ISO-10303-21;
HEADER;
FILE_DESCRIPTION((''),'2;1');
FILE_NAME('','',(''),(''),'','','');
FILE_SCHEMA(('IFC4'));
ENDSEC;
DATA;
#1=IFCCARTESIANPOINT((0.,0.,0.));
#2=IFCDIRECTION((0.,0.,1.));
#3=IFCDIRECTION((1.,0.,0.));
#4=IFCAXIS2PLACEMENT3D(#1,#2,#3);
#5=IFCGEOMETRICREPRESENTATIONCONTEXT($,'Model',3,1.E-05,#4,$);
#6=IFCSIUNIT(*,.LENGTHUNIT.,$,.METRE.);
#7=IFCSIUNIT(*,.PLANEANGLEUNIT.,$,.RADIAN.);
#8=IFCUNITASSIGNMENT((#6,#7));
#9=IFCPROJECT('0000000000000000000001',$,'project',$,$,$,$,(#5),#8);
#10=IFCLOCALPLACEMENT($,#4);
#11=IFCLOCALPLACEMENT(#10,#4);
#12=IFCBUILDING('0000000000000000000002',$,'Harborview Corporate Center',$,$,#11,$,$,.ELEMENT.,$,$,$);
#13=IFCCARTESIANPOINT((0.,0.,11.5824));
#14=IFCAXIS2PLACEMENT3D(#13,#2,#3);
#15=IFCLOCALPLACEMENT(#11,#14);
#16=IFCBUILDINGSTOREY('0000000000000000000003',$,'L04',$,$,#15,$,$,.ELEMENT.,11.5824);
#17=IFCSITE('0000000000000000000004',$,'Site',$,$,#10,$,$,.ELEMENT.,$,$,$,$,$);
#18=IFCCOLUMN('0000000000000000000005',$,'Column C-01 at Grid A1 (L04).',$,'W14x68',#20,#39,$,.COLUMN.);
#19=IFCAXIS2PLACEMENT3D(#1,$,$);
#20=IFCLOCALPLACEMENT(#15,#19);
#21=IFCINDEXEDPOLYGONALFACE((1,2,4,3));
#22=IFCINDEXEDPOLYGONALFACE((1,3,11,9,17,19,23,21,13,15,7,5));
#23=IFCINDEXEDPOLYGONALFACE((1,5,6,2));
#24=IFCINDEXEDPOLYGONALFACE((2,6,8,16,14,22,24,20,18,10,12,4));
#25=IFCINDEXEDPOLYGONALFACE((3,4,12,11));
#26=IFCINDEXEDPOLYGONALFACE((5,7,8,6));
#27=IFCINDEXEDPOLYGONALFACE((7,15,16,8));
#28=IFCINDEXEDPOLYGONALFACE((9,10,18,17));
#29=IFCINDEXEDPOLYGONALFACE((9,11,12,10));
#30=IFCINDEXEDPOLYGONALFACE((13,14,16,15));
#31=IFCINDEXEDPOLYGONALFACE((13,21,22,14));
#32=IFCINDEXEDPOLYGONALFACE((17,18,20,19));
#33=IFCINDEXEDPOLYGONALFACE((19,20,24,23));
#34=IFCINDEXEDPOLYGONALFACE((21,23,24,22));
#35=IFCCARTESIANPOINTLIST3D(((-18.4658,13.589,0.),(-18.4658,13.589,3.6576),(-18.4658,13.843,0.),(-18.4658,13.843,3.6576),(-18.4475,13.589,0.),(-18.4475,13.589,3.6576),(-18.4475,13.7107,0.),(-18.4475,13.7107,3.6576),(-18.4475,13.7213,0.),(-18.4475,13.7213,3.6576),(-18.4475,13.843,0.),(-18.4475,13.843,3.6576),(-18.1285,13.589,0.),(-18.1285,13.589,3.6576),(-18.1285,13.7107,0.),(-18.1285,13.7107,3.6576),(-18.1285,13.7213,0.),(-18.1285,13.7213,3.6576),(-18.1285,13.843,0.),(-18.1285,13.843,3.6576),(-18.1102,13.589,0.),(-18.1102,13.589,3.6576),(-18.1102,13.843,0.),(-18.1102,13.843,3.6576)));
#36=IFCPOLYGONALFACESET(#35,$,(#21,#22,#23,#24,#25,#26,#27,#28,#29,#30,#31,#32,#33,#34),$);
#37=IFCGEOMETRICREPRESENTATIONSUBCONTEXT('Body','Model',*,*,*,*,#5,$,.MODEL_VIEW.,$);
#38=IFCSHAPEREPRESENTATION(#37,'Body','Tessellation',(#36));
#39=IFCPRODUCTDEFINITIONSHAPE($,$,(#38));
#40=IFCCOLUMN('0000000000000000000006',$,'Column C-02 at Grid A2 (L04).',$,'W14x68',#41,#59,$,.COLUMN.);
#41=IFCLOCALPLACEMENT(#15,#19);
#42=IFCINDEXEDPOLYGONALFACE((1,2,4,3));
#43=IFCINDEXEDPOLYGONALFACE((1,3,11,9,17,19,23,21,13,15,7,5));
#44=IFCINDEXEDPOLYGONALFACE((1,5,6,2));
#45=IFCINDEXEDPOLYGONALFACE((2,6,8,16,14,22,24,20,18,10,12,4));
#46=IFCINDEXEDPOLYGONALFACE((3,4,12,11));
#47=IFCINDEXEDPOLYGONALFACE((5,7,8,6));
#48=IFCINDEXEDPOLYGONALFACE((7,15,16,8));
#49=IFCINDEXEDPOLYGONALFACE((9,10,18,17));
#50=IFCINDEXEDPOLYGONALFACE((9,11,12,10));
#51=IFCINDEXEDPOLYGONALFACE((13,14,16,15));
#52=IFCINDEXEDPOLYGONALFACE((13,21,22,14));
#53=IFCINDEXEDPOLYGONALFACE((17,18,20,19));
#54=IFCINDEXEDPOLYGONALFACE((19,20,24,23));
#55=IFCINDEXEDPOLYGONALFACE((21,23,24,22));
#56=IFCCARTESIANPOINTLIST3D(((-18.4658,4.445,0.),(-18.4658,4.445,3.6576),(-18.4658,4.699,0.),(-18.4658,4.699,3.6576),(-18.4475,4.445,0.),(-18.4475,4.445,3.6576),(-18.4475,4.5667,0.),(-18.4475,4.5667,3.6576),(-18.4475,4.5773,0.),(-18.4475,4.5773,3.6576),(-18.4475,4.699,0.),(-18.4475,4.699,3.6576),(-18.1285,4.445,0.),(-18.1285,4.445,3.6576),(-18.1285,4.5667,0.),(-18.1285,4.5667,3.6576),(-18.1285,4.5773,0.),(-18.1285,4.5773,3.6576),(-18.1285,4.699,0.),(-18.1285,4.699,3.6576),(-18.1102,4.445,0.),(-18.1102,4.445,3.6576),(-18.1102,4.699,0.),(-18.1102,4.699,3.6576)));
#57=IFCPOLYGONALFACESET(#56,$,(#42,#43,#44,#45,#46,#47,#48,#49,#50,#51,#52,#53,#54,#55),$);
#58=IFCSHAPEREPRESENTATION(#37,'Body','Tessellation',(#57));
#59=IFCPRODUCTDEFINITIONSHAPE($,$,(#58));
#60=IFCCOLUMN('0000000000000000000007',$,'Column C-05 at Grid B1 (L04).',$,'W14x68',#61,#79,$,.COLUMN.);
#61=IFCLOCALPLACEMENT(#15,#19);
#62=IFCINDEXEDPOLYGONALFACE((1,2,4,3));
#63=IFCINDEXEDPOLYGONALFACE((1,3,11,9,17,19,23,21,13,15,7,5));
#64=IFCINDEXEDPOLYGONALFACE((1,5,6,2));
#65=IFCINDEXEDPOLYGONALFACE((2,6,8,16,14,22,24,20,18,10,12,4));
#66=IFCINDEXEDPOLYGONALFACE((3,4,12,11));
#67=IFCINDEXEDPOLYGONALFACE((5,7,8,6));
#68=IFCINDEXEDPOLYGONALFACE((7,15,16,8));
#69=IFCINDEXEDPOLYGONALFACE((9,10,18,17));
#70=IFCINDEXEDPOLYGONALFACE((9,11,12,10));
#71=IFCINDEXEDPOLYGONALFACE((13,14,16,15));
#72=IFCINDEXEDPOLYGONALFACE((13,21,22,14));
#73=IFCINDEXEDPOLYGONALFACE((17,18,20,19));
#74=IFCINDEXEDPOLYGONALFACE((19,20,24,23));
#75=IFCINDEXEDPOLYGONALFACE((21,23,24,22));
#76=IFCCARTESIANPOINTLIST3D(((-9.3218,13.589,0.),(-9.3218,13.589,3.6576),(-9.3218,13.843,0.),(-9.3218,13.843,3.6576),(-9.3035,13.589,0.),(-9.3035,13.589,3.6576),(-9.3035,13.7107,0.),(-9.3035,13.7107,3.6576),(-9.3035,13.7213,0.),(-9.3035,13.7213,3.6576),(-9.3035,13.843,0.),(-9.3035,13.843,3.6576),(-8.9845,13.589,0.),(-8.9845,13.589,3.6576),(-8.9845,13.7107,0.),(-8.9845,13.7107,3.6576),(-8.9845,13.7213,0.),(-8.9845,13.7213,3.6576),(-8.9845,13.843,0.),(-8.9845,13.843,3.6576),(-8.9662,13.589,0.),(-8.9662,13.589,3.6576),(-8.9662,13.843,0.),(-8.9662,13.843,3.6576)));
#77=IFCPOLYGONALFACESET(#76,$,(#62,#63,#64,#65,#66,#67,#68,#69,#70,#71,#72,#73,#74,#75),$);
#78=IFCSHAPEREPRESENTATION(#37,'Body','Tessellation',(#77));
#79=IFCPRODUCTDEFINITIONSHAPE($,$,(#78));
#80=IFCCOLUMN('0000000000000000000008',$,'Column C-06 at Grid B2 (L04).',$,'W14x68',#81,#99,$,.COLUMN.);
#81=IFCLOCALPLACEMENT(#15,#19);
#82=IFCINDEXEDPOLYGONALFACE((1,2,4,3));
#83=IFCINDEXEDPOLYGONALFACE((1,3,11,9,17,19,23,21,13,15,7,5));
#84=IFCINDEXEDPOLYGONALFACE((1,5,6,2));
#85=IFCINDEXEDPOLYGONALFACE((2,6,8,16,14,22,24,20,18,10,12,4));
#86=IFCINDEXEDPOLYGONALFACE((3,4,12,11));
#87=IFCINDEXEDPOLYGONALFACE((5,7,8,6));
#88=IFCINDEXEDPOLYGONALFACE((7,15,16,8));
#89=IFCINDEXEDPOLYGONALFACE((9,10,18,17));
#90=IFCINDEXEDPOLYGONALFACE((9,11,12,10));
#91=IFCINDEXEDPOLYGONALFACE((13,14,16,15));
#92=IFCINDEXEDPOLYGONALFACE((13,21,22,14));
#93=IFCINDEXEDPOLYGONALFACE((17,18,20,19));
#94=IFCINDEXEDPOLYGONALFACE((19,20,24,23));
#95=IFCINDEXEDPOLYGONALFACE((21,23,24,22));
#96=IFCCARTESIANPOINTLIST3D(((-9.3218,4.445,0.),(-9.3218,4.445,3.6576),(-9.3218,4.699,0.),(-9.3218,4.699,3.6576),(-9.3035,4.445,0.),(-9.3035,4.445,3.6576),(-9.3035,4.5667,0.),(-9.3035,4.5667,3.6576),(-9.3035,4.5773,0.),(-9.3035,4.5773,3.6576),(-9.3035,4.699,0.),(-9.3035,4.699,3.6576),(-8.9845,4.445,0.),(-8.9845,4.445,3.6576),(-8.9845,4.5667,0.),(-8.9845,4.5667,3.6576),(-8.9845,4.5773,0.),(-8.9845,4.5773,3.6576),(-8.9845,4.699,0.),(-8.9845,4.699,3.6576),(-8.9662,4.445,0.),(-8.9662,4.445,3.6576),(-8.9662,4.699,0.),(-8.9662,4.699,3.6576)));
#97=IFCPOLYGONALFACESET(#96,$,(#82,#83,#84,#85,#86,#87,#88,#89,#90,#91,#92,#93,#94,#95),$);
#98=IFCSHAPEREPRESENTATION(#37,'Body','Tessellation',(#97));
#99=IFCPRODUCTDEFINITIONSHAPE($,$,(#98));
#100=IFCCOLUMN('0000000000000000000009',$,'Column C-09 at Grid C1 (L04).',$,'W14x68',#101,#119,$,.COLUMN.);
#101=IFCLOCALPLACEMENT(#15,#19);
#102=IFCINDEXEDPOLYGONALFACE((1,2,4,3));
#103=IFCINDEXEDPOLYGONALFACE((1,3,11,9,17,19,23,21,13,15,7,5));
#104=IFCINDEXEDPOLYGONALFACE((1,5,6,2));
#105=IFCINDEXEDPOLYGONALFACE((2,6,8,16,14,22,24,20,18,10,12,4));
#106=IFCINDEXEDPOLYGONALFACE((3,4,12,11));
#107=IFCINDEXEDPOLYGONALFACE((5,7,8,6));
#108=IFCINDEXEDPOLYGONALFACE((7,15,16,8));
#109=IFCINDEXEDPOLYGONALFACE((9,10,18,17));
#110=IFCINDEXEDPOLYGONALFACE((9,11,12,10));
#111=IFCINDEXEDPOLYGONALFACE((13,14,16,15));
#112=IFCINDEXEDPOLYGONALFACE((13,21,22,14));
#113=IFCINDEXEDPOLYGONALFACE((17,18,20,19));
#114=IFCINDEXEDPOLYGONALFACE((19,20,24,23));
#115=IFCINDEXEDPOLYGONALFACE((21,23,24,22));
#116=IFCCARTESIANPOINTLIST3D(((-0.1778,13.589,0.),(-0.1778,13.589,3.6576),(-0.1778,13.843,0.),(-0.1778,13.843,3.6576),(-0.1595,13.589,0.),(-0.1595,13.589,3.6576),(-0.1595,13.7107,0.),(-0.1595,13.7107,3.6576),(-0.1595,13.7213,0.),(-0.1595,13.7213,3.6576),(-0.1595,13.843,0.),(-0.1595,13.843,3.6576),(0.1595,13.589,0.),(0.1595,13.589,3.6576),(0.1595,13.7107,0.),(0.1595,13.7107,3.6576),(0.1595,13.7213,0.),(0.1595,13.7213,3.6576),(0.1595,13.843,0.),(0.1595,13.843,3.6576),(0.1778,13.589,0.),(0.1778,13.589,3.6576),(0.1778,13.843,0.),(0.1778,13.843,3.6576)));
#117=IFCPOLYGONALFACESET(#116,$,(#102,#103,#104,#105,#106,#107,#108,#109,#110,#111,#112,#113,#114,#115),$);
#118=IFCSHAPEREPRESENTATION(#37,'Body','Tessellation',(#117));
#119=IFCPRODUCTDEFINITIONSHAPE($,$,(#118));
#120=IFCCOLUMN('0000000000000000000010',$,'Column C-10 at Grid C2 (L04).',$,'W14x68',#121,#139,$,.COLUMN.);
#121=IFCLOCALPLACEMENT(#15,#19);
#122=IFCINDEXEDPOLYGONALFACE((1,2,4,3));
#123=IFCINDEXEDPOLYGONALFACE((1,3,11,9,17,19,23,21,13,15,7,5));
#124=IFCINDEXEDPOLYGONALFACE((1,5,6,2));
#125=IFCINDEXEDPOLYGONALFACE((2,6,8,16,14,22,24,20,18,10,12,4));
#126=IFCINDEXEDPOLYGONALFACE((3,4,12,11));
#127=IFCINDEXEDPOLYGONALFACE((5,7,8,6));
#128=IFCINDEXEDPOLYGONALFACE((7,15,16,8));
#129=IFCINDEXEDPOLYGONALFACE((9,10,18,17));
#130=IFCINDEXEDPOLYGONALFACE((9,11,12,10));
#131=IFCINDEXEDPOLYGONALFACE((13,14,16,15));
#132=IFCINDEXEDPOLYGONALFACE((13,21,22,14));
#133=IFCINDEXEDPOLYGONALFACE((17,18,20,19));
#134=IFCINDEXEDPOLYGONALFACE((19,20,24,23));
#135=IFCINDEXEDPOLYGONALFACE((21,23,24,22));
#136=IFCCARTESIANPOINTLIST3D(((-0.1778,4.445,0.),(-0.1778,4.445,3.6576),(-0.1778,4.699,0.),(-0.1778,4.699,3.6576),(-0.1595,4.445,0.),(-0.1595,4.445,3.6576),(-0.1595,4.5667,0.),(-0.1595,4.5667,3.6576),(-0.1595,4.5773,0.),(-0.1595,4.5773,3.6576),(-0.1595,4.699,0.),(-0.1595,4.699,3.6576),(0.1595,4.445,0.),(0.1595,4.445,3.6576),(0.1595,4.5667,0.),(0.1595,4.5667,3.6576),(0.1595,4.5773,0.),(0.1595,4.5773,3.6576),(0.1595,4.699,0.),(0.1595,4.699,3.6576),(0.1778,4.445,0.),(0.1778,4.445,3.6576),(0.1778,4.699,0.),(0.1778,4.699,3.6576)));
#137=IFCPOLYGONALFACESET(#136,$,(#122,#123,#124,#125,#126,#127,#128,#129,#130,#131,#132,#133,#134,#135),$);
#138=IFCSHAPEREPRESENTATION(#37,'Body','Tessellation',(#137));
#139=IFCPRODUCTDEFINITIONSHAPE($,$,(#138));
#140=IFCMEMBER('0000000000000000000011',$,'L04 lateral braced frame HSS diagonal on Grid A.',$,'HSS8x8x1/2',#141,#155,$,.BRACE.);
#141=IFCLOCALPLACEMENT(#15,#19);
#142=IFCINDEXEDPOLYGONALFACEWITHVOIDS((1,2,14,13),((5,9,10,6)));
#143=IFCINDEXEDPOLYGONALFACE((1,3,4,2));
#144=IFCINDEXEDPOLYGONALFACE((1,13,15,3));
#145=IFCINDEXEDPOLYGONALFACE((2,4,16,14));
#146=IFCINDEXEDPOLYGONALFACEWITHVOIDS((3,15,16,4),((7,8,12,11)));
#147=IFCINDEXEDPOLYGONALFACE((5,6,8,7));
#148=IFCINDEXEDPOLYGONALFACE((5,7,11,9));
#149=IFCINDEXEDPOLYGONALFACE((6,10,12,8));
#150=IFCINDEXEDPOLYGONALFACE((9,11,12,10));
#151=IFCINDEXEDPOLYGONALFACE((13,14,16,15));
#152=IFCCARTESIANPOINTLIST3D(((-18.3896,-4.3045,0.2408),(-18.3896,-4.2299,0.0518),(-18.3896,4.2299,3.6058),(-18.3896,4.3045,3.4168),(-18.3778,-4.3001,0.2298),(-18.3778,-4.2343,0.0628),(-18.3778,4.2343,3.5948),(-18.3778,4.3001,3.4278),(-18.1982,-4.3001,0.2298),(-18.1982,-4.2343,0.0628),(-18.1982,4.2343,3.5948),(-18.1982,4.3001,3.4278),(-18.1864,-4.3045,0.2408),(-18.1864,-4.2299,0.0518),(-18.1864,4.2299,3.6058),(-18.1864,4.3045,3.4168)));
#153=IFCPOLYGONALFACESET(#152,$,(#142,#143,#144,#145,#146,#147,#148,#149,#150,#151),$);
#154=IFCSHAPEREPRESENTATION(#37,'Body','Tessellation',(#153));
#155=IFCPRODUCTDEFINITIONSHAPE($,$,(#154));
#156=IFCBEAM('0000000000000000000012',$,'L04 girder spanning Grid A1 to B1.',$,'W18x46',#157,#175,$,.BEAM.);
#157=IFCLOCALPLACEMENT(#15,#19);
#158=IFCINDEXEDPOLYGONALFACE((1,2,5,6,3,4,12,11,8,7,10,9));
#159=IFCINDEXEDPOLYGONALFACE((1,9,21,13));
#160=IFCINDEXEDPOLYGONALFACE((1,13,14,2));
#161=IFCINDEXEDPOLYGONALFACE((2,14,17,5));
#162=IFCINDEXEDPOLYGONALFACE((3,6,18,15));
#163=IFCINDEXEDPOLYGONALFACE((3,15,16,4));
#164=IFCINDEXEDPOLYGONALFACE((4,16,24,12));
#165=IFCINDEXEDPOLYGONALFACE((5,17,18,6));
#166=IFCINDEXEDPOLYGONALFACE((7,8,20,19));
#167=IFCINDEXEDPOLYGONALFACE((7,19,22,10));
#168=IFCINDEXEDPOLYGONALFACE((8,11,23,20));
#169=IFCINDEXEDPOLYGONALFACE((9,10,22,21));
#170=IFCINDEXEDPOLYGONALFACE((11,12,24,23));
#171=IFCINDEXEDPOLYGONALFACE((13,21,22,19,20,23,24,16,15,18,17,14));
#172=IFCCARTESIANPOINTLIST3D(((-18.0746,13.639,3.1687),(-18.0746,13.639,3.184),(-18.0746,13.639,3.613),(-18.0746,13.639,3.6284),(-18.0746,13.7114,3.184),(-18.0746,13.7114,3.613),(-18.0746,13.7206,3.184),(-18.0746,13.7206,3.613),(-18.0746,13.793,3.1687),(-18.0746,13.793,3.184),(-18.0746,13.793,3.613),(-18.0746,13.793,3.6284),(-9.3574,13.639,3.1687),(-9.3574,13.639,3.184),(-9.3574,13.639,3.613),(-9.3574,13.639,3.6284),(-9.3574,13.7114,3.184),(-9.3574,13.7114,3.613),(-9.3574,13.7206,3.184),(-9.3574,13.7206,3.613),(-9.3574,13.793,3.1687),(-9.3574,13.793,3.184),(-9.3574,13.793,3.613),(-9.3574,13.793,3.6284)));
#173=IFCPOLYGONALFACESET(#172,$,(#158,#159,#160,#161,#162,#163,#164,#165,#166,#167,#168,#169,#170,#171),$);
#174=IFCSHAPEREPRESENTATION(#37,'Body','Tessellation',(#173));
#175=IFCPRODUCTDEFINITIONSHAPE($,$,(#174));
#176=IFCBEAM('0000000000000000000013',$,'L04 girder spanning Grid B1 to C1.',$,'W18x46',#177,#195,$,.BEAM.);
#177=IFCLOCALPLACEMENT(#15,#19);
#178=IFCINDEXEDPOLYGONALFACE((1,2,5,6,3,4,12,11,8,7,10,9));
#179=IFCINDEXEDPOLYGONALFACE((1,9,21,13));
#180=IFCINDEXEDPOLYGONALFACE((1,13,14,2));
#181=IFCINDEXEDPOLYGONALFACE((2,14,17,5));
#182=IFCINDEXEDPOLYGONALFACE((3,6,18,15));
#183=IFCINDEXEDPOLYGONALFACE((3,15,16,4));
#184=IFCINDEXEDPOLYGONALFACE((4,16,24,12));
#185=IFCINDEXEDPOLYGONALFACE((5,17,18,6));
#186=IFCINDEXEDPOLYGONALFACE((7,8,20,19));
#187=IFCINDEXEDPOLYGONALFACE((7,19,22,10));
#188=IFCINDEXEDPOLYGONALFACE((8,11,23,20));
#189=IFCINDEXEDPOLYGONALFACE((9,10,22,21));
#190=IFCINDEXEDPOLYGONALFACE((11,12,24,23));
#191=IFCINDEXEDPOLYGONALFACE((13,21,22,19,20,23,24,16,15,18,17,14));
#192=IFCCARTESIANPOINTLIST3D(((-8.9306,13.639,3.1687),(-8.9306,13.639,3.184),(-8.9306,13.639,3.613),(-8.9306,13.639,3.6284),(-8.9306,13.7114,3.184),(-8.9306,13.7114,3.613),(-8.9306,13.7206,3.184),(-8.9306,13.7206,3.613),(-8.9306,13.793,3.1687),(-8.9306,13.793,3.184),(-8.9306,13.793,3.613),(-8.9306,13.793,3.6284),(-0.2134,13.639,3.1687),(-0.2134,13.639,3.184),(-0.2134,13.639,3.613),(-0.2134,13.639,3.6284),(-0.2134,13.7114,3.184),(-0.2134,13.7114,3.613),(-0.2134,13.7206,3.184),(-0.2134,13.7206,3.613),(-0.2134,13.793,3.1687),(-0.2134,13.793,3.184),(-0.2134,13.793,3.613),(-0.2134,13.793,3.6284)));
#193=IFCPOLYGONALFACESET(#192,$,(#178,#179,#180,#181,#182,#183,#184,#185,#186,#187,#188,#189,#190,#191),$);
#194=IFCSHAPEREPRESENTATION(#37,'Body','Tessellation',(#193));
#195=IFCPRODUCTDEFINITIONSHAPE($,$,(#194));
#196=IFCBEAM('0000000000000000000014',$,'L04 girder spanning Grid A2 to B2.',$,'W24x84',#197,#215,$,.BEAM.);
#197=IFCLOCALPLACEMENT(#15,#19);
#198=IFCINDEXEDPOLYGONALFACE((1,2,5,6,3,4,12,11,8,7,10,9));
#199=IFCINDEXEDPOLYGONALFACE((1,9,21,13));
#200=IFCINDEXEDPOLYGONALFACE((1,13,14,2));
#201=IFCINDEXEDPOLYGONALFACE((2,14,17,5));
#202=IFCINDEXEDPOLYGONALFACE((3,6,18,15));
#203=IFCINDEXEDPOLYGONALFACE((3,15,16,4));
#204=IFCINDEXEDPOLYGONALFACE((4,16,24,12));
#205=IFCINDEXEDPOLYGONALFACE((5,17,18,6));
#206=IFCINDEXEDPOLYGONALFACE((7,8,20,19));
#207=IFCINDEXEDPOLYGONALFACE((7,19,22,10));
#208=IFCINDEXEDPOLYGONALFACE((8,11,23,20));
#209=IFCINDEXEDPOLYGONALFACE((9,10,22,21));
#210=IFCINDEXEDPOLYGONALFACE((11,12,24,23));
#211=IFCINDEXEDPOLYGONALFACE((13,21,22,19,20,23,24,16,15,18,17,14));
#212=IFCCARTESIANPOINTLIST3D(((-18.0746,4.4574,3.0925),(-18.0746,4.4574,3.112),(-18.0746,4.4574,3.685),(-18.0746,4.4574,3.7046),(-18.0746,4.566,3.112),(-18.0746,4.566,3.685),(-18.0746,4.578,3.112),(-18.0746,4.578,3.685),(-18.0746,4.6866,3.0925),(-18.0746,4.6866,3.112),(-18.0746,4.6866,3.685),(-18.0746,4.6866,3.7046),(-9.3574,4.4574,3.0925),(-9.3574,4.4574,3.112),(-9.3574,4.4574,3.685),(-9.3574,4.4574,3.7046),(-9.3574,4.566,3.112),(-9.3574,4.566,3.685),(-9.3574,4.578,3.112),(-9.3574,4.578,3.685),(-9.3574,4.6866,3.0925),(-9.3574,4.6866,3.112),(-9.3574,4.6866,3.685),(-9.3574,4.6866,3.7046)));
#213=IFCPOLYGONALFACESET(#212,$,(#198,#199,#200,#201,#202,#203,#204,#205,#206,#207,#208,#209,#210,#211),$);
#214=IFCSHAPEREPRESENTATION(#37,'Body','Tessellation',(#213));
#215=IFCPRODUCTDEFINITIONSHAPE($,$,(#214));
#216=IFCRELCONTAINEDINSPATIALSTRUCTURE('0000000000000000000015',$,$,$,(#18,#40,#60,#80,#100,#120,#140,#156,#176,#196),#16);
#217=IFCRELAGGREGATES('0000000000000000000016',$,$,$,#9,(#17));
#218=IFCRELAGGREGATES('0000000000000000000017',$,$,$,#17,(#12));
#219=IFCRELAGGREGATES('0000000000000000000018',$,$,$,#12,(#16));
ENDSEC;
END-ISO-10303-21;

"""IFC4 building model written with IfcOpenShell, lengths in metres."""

from ifc_helpers import new_model, si_unit, frame, origin_with_axes, place, context, subcontext, project, spatial, hollow_rectangle, i_section, extrude, element, save


model = new_model("IFC4")

# Units and contexts
model_context = context("Model", 3, precision=1e-05, world=origin_with_axes())
body_context = subcontext(model_context, "Body", "Model", "MODEL_VIEW")
ifc_project = project(units=[si_unit("LENGTHUNIT", "METRE"), si_unit("PLANEANGLEUNIT", "RADIAN")], contexts=[model_context])

# Site, building, storey
site_placement = place(None, origin_with_axes())
site = spatial("IfcSite", under=ifc_project, at=site_placement, Name="Site", CompositionType="ELEMENT")
building_placement = place(site_placement, origin_with_axes())
building = spatial("IfcBuilding", under=site, at=building_placement, Name="Harborview Corporate Center", CompositionType="ELEMENT")
storey_placement = place(building_placement, frame((0.0, 0.0, 11.5824), z_axis=(0.0, 0.0, 1.0), x_axis=(1.0, 0.0, 0.0)))
storey = spatial("IfcBuildingStorey", under=building, at=storey_placement, Name="L04", CompositionType="ELEMENT", Elevation=11.5824)

# Columns
for number, where, z_axis, x_axis, name in (
    (1, (-18.288, 13.716, 0.0), (0.0, 0.0, 1.0), (0.0, 1.0, 0.0), "Column C-01 at Grid A1 (L04)."),
    (2, (-18.288, 4.572, 0.0), (0.0, 0.0, 1.0), (0.0, 1.0, 0.0), "Column C-02 at Grid A2 (L04)."),
    (3, (-9.144, 13.716, 0.0), (0.0, 0.0, 1.0), (0.0, 1.0, 0.0), "Column C-05 at Grid B1 (L04)."),
    (4, (-9.144, 4.572, 0.0), (0.0, 0.0, 1.0), (0.0, 1.0, 0.0), "Column C-06 at Grid B2 (L04)."),
    (5, (0.0, 13.716, 0.0), (0.0, 0.0, 1.0), (0.0, 1.0, 0.0), "Column C-09 at Grid C1 (L04)."),
    (6, (0.0, 4.572, 0.0), (0.0, 0.0, 1.0), (0.0, 1.0, 0.0), "Column C-10 at Grid C2 (L04)."),
):
    element("IfcColumn", number, at=place(storey_placement, frame(where, z_axis=z_axis, x_axis=x_axis)), inside=storey, Name=name, ObjectType="W14x68", PredefinedType="COLUMN", context=body_context, shape_type="SweptSolid", body=[
        extrude(i_section(OverallWidth=0.254, OverallDepth=0.3556, WebThickness=0.0105, FlangeThickness=0.0183), origin_with_axes(), (0.0, 0.0, 1.0), 3.6576),
    ])

# Member
member_placement = place(storey_placement, frame((-18.288, -4.2672, 0.1463), z_axis=(0.0, 0.930298, 0.366803), x_axis=(-1.0, 0.0, 0.0)))
element("IfcMember", 7, at=member_placement, inside=storey, Name="L04 lateral braced frame HSS diagonal on Grid A.", ObjectType="HSS8x8x1/2", PredefinedType="BRACE", context=body_context, shape_type="SweptSolid", body=[
    extrude(hollow_rectangle(XDim=0.2032, YDim=0.2032, WallThickness=0.0118), origin_with_axes(), (0.0, 0.0, 1.0), 9.1738),
])

# Beams
beam_1_placement = place(storey_placement, frame((-18.0746, 13.716, 3.3985), z_axis=(1.0, 0.0, 0.0), x_axis=(0.0, 1.0, 0.0)))
element("IfcBeam", 8, at=beam_1_placement, inside=storey, Name="L04 girder spanning Grid A1 to B1.", ObjectType="W18x46", PredefinedType="BEAM", context=body_context, shape_type="SweptSolid", body=[
    extrude(i_section(OverallWidth=0.1539, OverallDepth=0.4597, WebThickness=0.0091, FlangeThickness=0.0154), origin_with_axes(), (0.0, 0.0, 1.0), 8.7173),
])
beam_2_placement = place(storey_placement, frame((-8.9306, 13.716, 3.3985), z_axis=(1.0, 0.0, 0.0), x_axis=(0.0, 1.0, 0.0)))
element("IfcBeam", 9, at=beam_2_placement, inside=storey, Name="L04 girder spanning Grid B1 to C1.", ObjectType="W18x46", PredefinedType="BEAM", context=body_context, shape_type="SweptSolid", body=[
    extrude(i_section(OverallWidth=0.1539, OverallDepth=0.4597, WebThickness=0.0091, FlangeThickness=0.0154), origin_with_axes(), (0.0, 0.0, 1.0), 8.7173),
])
beam_3_placement = place(storey_placement, frame((-18.0746, 4.572, 3.3985), z_axis=(1.0, 0.0, 0.0), x_axis=(0.0, 1.0, 0.0)))
element("IfcBeam", 10, at=beam_3_placement, inside=storey, Name="L04 girder spanning Grid A2 to B2.", ObjectType="W24x84", PredefinedType="BEAM", context=body_context, shape_type="SweptSolid", body=[
    extrude(i_section(OverallWidth=0.2291, OverallDepth=0.6121, WebThickness=0.0119, FlangeThickness=0.0196), origin_with_axes(), (0.0, 0.0, 1.0), 8.7173),
])

save(model, "model.ifc")
